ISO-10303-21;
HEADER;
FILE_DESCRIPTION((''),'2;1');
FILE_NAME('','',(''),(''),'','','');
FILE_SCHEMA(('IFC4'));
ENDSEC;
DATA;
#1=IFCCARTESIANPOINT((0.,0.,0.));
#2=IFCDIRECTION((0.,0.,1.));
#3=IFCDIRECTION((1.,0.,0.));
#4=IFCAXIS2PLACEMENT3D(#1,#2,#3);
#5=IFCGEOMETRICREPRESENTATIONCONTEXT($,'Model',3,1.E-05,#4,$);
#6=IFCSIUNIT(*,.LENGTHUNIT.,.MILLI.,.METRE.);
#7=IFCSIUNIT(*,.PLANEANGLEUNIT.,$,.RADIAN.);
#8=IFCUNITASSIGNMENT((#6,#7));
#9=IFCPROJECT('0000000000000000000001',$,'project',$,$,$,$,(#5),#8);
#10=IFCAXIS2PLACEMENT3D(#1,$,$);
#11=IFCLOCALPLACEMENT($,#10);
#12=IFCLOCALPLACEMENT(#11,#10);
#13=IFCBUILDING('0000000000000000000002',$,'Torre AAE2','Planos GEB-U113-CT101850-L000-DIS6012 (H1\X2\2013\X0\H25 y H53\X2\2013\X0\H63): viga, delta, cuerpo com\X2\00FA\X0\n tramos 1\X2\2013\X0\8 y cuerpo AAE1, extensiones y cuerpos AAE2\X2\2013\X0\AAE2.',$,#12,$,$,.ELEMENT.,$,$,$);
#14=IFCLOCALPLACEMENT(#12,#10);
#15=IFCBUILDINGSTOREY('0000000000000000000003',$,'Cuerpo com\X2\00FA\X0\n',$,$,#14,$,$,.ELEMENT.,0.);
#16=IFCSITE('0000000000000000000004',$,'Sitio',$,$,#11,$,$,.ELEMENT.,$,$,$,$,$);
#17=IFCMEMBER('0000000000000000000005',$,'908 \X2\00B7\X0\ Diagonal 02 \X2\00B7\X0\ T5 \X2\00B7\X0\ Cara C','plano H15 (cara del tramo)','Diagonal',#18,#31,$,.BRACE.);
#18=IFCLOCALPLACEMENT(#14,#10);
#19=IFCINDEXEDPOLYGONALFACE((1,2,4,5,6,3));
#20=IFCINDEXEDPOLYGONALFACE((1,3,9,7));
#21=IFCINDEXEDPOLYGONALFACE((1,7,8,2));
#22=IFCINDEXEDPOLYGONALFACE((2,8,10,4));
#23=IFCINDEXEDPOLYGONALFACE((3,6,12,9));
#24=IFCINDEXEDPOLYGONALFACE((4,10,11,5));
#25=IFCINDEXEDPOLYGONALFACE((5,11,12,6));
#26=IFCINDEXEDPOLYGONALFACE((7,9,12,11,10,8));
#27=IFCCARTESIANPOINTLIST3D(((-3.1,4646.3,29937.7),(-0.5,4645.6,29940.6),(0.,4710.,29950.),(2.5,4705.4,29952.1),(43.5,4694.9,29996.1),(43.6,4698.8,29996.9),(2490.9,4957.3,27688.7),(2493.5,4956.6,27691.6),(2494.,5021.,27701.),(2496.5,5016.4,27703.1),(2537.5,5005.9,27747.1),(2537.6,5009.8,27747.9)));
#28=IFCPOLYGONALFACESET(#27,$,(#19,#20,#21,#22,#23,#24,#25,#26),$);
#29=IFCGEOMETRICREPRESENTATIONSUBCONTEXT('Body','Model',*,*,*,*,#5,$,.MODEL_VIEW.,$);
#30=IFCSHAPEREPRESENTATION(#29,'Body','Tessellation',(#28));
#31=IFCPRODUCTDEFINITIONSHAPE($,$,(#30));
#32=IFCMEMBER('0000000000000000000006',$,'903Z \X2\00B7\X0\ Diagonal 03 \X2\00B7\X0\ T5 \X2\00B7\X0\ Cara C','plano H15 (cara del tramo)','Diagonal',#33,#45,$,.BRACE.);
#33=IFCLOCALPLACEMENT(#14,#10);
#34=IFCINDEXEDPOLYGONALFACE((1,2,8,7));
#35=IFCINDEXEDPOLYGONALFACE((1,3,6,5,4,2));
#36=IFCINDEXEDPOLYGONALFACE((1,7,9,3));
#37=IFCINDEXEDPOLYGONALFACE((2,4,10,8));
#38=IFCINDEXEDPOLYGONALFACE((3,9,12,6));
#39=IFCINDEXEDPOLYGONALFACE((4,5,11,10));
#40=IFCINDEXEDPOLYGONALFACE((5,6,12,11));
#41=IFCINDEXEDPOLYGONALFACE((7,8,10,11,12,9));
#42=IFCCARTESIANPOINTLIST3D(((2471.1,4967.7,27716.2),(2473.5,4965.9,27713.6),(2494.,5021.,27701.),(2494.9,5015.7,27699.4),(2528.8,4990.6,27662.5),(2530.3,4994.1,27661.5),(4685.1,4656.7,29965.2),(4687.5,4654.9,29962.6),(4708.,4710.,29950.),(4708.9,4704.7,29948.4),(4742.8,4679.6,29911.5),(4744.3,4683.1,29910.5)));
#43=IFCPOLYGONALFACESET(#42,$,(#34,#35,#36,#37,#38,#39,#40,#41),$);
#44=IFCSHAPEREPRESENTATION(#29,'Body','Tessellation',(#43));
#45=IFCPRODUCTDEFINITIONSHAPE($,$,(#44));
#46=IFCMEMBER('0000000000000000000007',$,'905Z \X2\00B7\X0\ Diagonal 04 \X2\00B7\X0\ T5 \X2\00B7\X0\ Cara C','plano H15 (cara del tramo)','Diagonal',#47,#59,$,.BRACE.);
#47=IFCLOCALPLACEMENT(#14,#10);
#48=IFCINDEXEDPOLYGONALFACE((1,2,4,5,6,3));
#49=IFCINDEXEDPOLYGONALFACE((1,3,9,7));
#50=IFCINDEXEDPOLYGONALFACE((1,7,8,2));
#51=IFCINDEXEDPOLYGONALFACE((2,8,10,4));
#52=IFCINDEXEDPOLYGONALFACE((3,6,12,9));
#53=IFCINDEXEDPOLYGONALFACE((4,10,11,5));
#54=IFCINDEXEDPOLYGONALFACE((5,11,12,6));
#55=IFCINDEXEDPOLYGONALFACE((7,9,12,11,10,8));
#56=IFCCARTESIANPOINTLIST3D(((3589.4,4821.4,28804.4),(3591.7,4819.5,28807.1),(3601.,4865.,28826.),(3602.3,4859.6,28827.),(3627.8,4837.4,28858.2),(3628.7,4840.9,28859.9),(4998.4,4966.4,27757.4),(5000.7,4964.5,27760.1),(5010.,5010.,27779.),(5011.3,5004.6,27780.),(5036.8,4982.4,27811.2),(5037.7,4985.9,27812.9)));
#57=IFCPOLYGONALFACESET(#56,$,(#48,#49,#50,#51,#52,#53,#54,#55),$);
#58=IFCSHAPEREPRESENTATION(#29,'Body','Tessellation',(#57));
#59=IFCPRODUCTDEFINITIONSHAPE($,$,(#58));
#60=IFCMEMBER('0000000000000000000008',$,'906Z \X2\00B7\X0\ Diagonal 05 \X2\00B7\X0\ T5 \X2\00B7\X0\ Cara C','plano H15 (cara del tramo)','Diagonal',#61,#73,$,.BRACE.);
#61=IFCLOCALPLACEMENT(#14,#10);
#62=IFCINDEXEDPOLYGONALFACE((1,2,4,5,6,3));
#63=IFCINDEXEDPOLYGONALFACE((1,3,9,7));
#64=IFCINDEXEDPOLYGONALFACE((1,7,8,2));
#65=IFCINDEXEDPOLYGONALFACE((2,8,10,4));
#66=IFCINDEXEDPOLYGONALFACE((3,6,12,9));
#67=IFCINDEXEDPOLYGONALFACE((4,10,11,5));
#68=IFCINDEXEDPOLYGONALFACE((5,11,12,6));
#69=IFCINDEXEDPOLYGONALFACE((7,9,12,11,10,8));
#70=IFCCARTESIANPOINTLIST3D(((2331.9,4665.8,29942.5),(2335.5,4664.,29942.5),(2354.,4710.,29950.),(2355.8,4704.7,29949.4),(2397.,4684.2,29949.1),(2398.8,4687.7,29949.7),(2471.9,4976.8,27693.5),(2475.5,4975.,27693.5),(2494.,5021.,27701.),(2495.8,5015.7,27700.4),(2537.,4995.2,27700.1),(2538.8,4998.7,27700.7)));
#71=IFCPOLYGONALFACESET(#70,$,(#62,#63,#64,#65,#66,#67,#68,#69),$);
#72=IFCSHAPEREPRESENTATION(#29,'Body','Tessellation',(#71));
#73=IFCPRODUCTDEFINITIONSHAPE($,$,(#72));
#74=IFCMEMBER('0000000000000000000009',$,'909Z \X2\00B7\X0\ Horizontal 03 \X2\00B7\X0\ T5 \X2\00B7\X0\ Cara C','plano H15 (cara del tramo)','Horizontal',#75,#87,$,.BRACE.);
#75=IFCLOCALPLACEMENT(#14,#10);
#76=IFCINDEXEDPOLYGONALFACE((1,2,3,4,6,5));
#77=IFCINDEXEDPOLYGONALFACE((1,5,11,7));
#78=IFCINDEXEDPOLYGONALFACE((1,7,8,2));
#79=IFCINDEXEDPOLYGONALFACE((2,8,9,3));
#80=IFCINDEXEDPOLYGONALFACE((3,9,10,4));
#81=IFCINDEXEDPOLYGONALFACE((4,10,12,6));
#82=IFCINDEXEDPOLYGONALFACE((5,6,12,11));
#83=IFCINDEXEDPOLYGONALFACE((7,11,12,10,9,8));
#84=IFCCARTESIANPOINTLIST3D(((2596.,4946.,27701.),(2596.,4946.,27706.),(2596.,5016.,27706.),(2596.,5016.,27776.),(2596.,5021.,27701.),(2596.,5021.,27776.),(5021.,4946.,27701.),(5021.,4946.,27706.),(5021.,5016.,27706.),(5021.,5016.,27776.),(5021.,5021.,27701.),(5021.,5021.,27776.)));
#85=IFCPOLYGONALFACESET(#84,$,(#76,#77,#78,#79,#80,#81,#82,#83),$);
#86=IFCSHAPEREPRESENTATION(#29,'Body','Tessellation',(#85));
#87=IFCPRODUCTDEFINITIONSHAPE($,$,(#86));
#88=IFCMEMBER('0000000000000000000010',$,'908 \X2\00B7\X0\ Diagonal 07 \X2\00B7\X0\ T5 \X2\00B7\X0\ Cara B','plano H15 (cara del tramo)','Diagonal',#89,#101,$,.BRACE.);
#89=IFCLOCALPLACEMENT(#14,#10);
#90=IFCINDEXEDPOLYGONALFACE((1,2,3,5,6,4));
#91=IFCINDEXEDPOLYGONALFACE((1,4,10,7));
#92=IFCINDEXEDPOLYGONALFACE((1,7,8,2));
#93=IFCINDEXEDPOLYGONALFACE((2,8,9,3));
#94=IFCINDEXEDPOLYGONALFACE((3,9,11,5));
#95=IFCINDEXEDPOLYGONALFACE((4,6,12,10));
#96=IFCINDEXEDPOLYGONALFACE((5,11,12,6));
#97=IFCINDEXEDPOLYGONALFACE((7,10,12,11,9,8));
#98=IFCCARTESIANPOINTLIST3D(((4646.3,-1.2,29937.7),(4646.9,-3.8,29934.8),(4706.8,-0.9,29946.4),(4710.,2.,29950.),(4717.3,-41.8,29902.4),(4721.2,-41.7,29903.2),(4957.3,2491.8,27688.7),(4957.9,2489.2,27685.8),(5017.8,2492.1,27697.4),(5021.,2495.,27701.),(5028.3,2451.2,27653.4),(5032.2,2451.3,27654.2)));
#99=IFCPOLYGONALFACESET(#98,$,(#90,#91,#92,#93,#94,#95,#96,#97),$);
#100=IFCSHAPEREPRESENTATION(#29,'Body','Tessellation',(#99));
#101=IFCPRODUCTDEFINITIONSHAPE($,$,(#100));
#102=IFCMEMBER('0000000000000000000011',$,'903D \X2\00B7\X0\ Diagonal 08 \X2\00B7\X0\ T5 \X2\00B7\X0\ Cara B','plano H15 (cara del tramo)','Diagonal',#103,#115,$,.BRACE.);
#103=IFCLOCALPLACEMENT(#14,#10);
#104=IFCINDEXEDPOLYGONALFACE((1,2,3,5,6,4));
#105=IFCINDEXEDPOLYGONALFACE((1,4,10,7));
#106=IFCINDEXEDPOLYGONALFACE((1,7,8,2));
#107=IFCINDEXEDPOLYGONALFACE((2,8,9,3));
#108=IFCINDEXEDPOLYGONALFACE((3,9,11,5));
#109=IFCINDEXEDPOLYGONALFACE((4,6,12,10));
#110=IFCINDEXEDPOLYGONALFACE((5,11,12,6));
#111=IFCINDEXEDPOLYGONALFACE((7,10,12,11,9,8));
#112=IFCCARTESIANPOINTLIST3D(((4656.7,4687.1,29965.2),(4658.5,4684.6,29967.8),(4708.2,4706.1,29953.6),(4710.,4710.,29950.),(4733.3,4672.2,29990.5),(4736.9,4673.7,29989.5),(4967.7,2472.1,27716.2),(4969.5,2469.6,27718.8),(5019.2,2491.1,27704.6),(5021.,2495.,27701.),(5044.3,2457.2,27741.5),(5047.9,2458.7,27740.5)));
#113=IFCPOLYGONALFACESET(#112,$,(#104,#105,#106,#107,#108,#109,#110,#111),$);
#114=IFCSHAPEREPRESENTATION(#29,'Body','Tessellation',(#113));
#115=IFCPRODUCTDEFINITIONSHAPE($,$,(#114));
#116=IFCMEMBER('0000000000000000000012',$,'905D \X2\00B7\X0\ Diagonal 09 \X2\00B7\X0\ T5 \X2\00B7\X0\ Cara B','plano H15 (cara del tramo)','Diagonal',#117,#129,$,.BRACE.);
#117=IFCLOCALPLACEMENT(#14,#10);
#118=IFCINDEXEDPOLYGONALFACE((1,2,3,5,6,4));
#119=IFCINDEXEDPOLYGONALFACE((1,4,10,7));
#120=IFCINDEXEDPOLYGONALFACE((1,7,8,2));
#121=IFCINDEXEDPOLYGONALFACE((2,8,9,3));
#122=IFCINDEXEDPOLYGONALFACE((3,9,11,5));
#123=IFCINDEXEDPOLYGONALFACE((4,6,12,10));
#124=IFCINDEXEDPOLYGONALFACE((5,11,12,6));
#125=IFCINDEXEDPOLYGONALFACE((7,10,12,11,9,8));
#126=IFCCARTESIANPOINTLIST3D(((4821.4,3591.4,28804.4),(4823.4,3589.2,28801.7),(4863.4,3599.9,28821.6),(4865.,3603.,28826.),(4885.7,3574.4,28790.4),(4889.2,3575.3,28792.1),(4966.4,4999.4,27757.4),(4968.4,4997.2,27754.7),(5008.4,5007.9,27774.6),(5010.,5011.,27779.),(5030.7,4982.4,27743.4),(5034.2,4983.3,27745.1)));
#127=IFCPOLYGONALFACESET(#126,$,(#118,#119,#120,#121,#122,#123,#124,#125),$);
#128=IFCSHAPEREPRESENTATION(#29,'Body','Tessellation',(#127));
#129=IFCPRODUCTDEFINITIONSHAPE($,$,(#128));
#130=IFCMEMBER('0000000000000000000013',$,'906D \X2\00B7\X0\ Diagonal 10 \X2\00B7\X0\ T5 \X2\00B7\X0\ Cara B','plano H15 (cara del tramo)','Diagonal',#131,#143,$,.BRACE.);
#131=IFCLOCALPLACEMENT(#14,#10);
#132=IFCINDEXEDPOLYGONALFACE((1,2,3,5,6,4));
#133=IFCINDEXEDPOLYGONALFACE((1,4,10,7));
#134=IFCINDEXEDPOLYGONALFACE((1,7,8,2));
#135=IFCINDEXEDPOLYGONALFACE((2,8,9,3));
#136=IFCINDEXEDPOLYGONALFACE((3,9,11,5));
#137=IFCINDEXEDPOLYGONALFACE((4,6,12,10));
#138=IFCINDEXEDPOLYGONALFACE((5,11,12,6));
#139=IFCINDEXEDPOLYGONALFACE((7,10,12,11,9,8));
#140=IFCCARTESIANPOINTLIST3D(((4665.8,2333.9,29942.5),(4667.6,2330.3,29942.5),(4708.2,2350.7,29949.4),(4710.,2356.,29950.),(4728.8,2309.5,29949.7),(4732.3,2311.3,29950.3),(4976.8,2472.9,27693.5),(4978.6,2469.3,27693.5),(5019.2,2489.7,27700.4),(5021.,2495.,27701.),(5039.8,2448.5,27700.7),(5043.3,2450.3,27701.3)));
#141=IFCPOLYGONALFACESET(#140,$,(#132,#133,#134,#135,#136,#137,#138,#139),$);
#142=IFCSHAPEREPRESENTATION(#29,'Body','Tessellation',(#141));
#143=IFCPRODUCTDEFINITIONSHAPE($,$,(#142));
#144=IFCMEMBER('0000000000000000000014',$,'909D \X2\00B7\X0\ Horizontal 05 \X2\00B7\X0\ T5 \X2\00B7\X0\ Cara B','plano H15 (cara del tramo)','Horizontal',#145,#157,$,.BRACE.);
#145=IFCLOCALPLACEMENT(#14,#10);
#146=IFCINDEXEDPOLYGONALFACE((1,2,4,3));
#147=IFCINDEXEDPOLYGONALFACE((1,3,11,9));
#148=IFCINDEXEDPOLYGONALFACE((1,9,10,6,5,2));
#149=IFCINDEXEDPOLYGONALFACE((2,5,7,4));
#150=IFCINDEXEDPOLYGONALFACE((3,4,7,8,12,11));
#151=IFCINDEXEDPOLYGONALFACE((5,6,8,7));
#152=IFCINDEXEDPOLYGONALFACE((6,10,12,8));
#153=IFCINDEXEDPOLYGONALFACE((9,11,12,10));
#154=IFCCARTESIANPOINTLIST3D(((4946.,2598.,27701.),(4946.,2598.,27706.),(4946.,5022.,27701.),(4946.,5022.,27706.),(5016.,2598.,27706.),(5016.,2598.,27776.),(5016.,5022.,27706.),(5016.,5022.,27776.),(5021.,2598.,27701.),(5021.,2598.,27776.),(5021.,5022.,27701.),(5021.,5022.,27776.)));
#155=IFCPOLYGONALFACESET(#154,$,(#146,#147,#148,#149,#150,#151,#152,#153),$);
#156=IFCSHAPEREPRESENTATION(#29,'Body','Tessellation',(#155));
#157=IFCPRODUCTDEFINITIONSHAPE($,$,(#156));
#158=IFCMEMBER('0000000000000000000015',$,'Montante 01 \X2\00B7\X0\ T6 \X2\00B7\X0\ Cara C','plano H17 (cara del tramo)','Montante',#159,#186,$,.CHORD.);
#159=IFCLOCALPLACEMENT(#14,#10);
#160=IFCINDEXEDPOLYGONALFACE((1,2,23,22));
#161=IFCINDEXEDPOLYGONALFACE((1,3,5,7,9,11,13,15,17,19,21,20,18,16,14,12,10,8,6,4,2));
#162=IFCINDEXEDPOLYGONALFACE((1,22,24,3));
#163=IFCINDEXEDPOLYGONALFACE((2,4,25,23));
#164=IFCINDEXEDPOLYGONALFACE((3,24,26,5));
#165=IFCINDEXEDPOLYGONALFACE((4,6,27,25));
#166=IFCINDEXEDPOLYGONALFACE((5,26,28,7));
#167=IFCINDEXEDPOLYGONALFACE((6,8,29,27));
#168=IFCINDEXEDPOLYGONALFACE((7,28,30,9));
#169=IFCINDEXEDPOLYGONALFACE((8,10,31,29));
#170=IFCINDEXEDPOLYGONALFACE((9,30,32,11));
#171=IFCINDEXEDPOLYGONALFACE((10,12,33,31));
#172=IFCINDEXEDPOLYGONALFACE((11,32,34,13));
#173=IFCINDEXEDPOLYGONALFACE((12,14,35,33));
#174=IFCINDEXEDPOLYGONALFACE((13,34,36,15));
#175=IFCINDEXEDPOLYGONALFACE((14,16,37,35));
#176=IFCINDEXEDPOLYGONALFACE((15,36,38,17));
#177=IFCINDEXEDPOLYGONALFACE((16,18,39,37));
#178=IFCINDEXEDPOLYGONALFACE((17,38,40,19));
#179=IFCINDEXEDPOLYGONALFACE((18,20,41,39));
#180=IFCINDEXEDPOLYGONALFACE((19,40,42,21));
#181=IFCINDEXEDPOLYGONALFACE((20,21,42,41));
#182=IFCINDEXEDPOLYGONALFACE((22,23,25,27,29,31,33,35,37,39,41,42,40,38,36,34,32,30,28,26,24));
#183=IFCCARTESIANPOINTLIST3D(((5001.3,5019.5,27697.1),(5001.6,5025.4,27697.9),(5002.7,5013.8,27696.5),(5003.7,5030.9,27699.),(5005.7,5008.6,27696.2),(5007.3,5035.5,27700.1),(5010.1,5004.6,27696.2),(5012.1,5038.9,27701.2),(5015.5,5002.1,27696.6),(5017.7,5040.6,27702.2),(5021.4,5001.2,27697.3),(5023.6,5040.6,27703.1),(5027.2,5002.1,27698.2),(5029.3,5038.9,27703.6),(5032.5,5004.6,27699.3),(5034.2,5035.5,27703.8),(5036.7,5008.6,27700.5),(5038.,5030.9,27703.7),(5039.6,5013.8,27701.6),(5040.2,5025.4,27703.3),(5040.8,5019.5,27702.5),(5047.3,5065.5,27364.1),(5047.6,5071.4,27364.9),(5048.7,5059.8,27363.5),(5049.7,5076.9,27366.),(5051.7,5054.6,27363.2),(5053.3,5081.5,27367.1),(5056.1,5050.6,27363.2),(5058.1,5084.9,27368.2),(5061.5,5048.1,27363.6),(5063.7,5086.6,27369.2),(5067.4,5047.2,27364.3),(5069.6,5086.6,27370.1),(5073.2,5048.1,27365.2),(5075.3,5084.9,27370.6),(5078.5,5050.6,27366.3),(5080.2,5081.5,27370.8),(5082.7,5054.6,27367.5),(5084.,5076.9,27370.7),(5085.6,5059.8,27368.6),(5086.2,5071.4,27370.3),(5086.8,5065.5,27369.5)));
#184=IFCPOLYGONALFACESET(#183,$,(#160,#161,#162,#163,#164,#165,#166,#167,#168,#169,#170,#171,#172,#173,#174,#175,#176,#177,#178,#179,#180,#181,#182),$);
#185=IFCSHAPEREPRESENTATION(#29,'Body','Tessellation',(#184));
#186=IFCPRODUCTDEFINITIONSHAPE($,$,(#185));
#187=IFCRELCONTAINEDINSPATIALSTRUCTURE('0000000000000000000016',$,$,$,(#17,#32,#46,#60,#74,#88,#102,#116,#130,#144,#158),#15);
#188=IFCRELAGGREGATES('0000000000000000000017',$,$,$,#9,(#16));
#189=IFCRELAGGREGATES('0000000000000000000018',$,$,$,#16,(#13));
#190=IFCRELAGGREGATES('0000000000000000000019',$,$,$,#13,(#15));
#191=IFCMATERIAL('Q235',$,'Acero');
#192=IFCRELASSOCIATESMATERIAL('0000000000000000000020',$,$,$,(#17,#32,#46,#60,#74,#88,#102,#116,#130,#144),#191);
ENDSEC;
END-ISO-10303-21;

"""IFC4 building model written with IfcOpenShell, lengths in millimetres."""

from ifc_helpers import new_model, si_unit, frame, frame_2d, origin, origin_with_axes, place, context, subcontext, project, spatial, circle, l_section, extrude, material, element, save


model = new_model("IFC4")

# Units and contexts
model_context = context("Model", 3, precision=1e-05, world=origin_with_axes())
body_context = subcontext(model_context, "Body", "Model", "MODEL_VIEW")
ifc_project = project(units=[si_unit("LENGTHUNIT", "METRE", prefix="MILLI"), si_unit("PLANEANGLEUNIT", "RADIAN")], contexts=[model_context])

# Site, building, storey
site_placement = place(None, origin())
site = spatial("IfcSite", under=ifc_project, at=site_placement, Name="Sitio", CompositionType="ELEMENT")
building_placement = place(site_placement, origin())
building = spatial("IfcBuilding", under=site, at=building_placement, Name="Torre AAE2", Description="Planos GEB-U113-CT101850-L000-DIS6012 (H1–H25 y H53–H63): viga, delta, cuerpo común tramos 1–8 y cuerpo AAE1, extensiones y cuerpos AAE2–AAE2.", CompositionType="ELEMENT")
storey_placement = place(building_placement, origin())
storey = spatial("IfcBuildingStorey", under=building, at=storey_placement, Name="Cuerpo común", CompositionType="ELEMENT", Elevation=0.0)

# Members
ifc_material_1 = material(Name="Q235", Category="Acero")
member_1_placement = place(storey_placement, frame((2494.0, 5021.0, 27701.0), z_axis=(-0.739478, -0.092212, 0.666835), x_axis=(-0.048288, -0.980756, -0.189171)))
element("IfcMember", 1, at=member_1_placement, inside=storey, material=ifc_material_1, Name="908 · Diagonal 02 · T5 · Cara C", Description="plano H15 (cara del tramo)", ObjectType="Diagonal", PredefinedType="BRACE", context=body_context, shape_type="SweptSolid", body=[
    extrude(l_section(Depth=65.0, Width=65.0, Thickness=4.0, at=frame_2d((32.5, 32.5))), None, (0.0, 0.0, 1.0), 3372.6),
])
member_2_placement = place(storey_placement, frame((2494.0, 5021.0, 27701.0), z_axis=(0.698158, -0.09807, 0.709195), x_axis=(-0.382258, -0.888624, 0.253427)))
element("IfcMember", 2, at=member_2_placement, inside=storey, material=ifc_material_1, Name="903Z · Diagonal 03 · T5 · Cara C", Description="plano H15 (cara del tramo)", ObjectType="Diagonal", PredefinedType="BRACE", context=body_context, shape_type="SweptSolid", body=[
    extrude(l_section(Depth=60.0, Width=60.0, Thickness=4.0, at=frame_2d((30.0, 30.0))), None, (0.0, 0.0, 1.0), 3171.2),
])
member_3_placement = place(storey_placement, frame((5010.0, 5010.0, 27779.0), z_axis=(-0.799934, -0.082321, 0.594415), x_axis=(-0.231191, -0.871806, -0.431862)))
element("IfcMember", 3, at=member_3_placement, inside=storey, material=ifc_material_1, Name="905Z · Diagonal 04 · T5 · Cara C", Description="plano H15 (cara del tramo)", ObjectType="Diagonal", PredefinedType="BRACE", context=body_context, shape_type="SweptSolid", body=[
    extrude(l_section(Depth=50.0, Width=50.0, Thickness=4.0, at=frame_2d((25.0, 25.0))), None, (0.0, 0.0, 1.0), 1761.4),
])
member_4_placement = place(storey_placement, frame((2494.0, 5021.0, 27701.0), z_axis=(-0.061546, -0.136721, 0.988696), x_axis=(-0.44169, -0.884571, -0.149817)))
element("IfcMember", 4, at=member_4_placement, inside=storey, material=ifc_material_1, Name="906Z · Diagonal 05 · T5 · Cara C", Description="plano H15 (cara del tramo)", ObjectType="Diagonal", PredefinedType="BRACE", context=body_context, shape_type="SweptSolid", body=[
    extrude(l_section(Depth=50.0, Width=50.0, Thickness=4.0, at=frame_2d((25.0, 25.0))), None, (0.0, 0.0, 1.0), 2274.7),
])
member_5_placement = place(storey_placement, frame((5021.0, 5021.0, 27701.0), z_axis=(-1.0, 0.0, 0.0), x_axis=(0.0, -1.0, 0.0)))
element("IfcMember", 5, at=member_5_placement, inside=storey, material=ifc_material_1, Name="909Z · Horizontal 03 · T5 · Cara C", Description="plano H15 (cara del tramo)", ObjectType="Horizontal", PredefinedType="BRACE", context=body_context, shape_type="SweptSolid", body=[
    extrude(l_section(Depth=75.0, Width=75.0, Thickness=5.0, at=frame_2d((37.5, 37.5))), None, (0.0, 0.0, 1.0), 2425.0),
])
member_6_placement = place(storey_placement, frame((5021.0, 2495.0, 27701.0), z_axis=(-0.092233, -0.739344, 0.666981), x_axis=(-0.980712, -0.048477, -0.189352)))
element("IfcMember", 6, at=member_6_placement, inside=storey, material=ifc_material_1, Name="908 · Diagonal 07 · T5 · Cara B", Description="plano H15 (cara del tramo)", ObjectType="Diagonal", PredefinedType="BRACE", context=body_context, shape_type="SweptSolid", body=[
    extrude(l_section(Depth=65.0, Width=65.0, Thickness=4.0, at=frame_2d((32.5, 32.5))), None, (0.0, 0.0, 1.0), 3371.9),
])
member_7_placement = place(storey_placement, frame((5021.0, 2495.0, 27701.0), z_axis=(-0.098049, 0.69832, 0.709039), x_axis=(-0.888595, -0.382229, 0.253573)))
element("IfcMember", 7, at=member_7_placement, inside=storey, material=ifc_material_1, Name="903D · Diagonal 08 · T5 · Cara B", Description="plano H15 (cara del tramo)", ObjectType="Diagonal", PredefinedType="BRACE", context=body_context, shape_type="SweptSolid", body=[
    extrude(l_section(Depth=60.0, Width=60.0, Thickness=4.0, at=frame_2d((30.0, 30.0))), None, (0.0, 0.0, 1.0), 3171.9),
])
member_8_placement = place(storey_placement, frame((5010.0, 5011.0, 27779.0), z_axis=(-0.082358, -0.799729, 0.594685), x_axis=(-0.871631, -0.231509, -0.432045)))
element("IfcMember", 8, at=member_8_placement, inside=storey, material=ifc_material_1, Name="905D · Diagonal 09 · T5 · Cara B", Description="plano H15 (cara del tramo)", ObjectType="Diagonal", PredefinedType="BRACE", context=body_context, shape_type="SweptSolid", body=[
    extrude(l_section(Depth=50.0, Width=50.0, Thickness=4.0, at=frame_2d((25.0, 25.0))), None, (0.0, 0.0, 1.0), 1760.6),
])
member_9_placement = place(storey_placement, frame((5021.0, 2495.0, 27701.0), z_axis=(-0.136724, -0.061108, 0.988723), x_axis=(-0.884459, -0.441979, -0.149623)))
element("IfcMember", 9, at=member_9_placement, inside=storey, material=ifc_material_1, Name="906D · Diagonal 10 · T5 · Cara B", Description="plano H15 (cara del tramo)", ObjectType="Diagonal", PredefinedType="BRACE", context=body_context, shape_type="SweptSolid", body=[
    extrude(l_section(Depth=50.0, Width=50.0, Thickness=4.0, at=frame_2d((25.0, 25.0))), None, (0.0, 0.0, 1.0), 2274.7),
])
member_10_placement = place(storey_placement, frame((5021.0, 2598.0, 27701.0), z_axis=(0.0, 1.0, 0.0), x_axis=(-1.0, 0.0, 0.0)))
element("IfcMember", 10, at=member_10_placement, inside=storey, material=ifc_material_1, Name="909D · Horizontal 05 · T5 · Cara B", Description="plano H15 (cara del tramo)", ObjectType="Horizontal", PredefinedType="BRACE", context=body_context, shape_type="SweptSolid", body=[
    extrude(l_section(Depth=75.0, Width=75.0, Thickness=5.0, at=frame_2d((37.5, 37.5))), None, (0.0, 0.0, 1.0), 2424.0),
])
member_11_placement = place(storey_placement, frame((5021.0, 5021.0, 27700.0), z_axis=(0.135575, 0.135575, -0.981447), x_axis=(0.018552, -0.990767, -0.1343)))
element("IfcMember", 11, at=member_11_placement, inside=storey, Name="Montante 01 · T6 · Cara C", Description="plano H17 (cara del tramo)", ObjectType="Montante", PredefinedType="CHORD", context=body_context, shape_type="SweptSolid", body=[
    extrude(circle(Radius=20.0), None, (0.0, 0.0, 1.0), 339.3),
])

save(model, "model.ifc")
